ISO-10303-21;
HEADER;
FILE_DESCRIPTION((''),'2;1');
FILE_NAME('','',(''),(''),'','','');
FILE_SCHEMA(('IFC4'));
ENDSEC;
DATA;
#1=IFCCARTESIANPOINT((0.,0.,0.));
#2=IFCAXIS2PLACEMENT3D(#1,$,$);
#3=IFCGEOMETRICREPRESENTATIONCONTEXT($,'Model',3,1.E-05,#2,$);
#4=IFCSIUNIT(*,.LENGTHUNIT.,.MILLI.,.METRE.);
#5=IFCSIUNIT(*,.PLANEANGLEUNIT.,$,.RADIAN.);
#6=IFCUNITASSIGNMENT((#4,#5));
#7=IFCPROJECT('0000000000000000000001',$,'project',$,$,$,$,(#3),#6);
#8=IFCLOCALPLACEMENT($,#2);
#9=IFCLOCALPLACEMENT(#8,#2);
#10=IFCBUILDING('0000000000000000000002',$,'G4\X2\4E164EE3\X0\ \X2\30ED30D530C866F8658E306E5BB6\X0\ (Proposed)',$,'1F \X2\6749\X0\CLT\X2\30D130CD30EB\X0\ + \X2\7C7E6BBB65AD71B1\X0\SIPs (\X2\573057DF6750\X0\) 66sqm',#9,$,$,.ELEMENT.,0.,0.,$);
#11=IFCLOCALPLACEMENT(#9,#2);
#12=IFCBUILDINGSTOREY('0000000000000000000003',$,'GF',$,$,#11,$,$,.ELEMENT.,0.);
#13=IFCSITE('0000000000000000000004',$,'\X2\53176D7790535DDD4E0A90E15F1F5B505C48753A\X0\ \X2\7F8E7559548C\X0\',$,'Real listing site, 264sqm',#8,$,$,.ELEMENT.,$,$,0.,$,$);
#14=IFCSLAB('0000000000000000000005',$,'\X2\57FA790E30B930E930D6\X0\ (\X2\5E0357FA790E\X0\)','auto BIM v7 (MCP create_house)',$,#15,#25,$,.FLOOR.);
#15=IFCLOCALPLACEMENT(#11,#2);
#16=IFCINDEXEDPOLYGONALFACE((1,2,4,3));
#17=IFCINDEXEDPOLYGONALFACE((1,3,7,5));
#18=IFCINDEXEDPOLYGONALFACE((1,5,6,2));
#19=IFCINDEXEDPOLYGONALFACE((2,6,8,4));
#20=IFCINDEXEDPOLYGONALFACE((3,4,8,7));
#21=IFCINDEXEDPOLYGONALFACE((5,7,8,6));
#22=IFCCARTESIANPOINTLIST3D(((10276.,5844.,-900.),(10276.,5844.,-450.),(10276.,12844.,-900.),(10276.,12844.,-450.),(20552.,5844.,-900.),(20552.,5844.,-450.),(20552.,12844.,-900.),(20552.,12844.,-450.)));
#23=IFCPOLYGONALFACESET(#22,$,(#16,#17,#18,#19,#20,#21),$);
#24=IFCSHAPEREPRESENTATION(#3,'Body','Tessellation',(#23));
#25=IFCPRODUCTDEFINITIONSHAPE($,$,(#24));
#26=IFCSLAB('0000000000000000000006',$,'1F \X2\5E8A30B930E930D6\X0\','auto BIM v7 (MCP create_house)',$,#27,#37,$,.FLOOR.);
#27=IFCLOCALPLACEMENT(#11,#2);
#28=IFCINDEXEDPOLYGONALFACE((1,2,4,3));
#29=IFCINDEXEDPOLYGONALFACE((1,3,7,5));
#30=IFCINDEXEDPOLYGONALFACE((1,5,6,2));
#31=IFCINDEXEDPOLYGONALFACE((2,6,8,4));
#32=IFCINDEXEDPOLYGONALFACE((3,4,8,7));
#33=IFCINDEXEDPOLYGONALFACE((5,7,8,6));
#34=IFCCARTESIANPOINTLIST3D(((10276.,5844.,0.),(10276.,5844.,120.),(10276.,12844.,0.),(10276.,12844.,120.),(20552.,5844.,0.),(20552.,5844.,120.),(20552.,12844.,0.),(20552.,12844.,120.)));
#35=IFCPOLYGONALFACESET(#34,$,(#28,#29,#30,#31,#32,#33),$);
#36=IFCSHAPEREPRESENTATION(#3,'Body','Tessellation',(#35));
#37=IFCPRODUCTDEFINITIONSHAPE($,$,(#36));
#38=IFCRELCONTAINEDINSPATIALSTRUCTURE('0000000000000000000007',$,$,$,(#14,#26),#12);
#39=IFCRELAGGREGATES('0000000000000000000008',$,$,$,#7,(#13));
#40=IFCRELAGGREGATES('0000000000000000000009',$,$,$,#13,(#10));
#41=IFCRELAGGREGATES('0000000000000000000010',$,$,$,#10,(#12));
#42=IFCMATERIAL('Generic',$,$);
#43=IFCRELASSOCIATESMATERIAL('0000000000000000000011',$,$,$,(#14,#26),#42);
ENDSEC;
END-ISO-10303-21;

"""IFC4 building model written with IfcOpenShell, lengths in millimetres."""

from ifc_helpers import new_model, si_unit, frame, frame_2d, origin, place, context, project, spatial, rectangle, extrude, material, element, save


model = new_model("IFC4")

# Units and contexts
model_context = context("Model", 3, precision=1e-05, world=origin())
ifc_project = project(units=[si_unit("LENGTHUNIT", "METRE", prefix="MILLI"), si_unit("PLANEANGLEUNIT", "RADIAN")], contexts=[model_context])

# Site, building, storey
site_placement = place(None, origin())
site = spatial("IfcSite", under=ifc_project, at=site_placement, Name="北海道川上郡弟子屈町 美留和", ObjectType="Real listing site, 264sqm", CompositionType="ELEMENT", RefElevation=0.0)
building_placement = place(site_placement, origin())
building = spatial("IfcBuilding", under=site, at=building_placement, Name="G4世代 ロフト書斎の家 (Proposed)", ObjectType="1F 杉CLTパネル + 籾殻断熱SIPs (地域材) 66sqm", CompositionType="ELEMENT", ElevationOfRefHeight=0.0, ElevationOfTerrain=0.0)
storey_placement = place(building_placement, origin())
storey = spatial("IfcBuildingStorey", under=building, at=storey_placement, Name="GF", CompositionType="ELEMENT", Elevation=0.0)

# Slabs
ifc_material = material(Name="Generic")
slab_1_placement = place(storey_placement, frame((5138.0, 2922.0, -450.0)))
element("IfcSlab", 1, at=slab_1_placement, inside=storey, material=ifc_material, Name="基礎スラブ (布基礎)", Description="auto BIM v7 (MCP create_house)", PredefinedType="FLOOR", context=model_context, shape_type="SweptSolid", body=[
    extrude(rectangle(XDim=10276.0, YDim=7000.0, at=frame_2d((5138.0, 3500.0))), frame((5138.0, 2922.0, -450.0)), (0.0, 0.0, 1.0), 450.0),
])
slab_2_placement = place(storey_placement, frame((5138.0, 2922.0, 0.0)))
element("IfcSlab", 2, at=slab_2_placement, inside=storey, material=ifc_material, Name="1F 床スラブ", Description="auto BIM v7 (MCP create_house)", PredefinedType="FLOOR", context=model_context, shape_type="SweptSolid", body=[
    extrude(rectangle(XDim=10276.0, YDim=7000.0, at=frame_2d((5138.0, 3500.0))), frame((5138.0, 2922.0, 0.0)), (0.0, 0.0, 1.0), 120.0),
])

save(model, "model.ifc")
